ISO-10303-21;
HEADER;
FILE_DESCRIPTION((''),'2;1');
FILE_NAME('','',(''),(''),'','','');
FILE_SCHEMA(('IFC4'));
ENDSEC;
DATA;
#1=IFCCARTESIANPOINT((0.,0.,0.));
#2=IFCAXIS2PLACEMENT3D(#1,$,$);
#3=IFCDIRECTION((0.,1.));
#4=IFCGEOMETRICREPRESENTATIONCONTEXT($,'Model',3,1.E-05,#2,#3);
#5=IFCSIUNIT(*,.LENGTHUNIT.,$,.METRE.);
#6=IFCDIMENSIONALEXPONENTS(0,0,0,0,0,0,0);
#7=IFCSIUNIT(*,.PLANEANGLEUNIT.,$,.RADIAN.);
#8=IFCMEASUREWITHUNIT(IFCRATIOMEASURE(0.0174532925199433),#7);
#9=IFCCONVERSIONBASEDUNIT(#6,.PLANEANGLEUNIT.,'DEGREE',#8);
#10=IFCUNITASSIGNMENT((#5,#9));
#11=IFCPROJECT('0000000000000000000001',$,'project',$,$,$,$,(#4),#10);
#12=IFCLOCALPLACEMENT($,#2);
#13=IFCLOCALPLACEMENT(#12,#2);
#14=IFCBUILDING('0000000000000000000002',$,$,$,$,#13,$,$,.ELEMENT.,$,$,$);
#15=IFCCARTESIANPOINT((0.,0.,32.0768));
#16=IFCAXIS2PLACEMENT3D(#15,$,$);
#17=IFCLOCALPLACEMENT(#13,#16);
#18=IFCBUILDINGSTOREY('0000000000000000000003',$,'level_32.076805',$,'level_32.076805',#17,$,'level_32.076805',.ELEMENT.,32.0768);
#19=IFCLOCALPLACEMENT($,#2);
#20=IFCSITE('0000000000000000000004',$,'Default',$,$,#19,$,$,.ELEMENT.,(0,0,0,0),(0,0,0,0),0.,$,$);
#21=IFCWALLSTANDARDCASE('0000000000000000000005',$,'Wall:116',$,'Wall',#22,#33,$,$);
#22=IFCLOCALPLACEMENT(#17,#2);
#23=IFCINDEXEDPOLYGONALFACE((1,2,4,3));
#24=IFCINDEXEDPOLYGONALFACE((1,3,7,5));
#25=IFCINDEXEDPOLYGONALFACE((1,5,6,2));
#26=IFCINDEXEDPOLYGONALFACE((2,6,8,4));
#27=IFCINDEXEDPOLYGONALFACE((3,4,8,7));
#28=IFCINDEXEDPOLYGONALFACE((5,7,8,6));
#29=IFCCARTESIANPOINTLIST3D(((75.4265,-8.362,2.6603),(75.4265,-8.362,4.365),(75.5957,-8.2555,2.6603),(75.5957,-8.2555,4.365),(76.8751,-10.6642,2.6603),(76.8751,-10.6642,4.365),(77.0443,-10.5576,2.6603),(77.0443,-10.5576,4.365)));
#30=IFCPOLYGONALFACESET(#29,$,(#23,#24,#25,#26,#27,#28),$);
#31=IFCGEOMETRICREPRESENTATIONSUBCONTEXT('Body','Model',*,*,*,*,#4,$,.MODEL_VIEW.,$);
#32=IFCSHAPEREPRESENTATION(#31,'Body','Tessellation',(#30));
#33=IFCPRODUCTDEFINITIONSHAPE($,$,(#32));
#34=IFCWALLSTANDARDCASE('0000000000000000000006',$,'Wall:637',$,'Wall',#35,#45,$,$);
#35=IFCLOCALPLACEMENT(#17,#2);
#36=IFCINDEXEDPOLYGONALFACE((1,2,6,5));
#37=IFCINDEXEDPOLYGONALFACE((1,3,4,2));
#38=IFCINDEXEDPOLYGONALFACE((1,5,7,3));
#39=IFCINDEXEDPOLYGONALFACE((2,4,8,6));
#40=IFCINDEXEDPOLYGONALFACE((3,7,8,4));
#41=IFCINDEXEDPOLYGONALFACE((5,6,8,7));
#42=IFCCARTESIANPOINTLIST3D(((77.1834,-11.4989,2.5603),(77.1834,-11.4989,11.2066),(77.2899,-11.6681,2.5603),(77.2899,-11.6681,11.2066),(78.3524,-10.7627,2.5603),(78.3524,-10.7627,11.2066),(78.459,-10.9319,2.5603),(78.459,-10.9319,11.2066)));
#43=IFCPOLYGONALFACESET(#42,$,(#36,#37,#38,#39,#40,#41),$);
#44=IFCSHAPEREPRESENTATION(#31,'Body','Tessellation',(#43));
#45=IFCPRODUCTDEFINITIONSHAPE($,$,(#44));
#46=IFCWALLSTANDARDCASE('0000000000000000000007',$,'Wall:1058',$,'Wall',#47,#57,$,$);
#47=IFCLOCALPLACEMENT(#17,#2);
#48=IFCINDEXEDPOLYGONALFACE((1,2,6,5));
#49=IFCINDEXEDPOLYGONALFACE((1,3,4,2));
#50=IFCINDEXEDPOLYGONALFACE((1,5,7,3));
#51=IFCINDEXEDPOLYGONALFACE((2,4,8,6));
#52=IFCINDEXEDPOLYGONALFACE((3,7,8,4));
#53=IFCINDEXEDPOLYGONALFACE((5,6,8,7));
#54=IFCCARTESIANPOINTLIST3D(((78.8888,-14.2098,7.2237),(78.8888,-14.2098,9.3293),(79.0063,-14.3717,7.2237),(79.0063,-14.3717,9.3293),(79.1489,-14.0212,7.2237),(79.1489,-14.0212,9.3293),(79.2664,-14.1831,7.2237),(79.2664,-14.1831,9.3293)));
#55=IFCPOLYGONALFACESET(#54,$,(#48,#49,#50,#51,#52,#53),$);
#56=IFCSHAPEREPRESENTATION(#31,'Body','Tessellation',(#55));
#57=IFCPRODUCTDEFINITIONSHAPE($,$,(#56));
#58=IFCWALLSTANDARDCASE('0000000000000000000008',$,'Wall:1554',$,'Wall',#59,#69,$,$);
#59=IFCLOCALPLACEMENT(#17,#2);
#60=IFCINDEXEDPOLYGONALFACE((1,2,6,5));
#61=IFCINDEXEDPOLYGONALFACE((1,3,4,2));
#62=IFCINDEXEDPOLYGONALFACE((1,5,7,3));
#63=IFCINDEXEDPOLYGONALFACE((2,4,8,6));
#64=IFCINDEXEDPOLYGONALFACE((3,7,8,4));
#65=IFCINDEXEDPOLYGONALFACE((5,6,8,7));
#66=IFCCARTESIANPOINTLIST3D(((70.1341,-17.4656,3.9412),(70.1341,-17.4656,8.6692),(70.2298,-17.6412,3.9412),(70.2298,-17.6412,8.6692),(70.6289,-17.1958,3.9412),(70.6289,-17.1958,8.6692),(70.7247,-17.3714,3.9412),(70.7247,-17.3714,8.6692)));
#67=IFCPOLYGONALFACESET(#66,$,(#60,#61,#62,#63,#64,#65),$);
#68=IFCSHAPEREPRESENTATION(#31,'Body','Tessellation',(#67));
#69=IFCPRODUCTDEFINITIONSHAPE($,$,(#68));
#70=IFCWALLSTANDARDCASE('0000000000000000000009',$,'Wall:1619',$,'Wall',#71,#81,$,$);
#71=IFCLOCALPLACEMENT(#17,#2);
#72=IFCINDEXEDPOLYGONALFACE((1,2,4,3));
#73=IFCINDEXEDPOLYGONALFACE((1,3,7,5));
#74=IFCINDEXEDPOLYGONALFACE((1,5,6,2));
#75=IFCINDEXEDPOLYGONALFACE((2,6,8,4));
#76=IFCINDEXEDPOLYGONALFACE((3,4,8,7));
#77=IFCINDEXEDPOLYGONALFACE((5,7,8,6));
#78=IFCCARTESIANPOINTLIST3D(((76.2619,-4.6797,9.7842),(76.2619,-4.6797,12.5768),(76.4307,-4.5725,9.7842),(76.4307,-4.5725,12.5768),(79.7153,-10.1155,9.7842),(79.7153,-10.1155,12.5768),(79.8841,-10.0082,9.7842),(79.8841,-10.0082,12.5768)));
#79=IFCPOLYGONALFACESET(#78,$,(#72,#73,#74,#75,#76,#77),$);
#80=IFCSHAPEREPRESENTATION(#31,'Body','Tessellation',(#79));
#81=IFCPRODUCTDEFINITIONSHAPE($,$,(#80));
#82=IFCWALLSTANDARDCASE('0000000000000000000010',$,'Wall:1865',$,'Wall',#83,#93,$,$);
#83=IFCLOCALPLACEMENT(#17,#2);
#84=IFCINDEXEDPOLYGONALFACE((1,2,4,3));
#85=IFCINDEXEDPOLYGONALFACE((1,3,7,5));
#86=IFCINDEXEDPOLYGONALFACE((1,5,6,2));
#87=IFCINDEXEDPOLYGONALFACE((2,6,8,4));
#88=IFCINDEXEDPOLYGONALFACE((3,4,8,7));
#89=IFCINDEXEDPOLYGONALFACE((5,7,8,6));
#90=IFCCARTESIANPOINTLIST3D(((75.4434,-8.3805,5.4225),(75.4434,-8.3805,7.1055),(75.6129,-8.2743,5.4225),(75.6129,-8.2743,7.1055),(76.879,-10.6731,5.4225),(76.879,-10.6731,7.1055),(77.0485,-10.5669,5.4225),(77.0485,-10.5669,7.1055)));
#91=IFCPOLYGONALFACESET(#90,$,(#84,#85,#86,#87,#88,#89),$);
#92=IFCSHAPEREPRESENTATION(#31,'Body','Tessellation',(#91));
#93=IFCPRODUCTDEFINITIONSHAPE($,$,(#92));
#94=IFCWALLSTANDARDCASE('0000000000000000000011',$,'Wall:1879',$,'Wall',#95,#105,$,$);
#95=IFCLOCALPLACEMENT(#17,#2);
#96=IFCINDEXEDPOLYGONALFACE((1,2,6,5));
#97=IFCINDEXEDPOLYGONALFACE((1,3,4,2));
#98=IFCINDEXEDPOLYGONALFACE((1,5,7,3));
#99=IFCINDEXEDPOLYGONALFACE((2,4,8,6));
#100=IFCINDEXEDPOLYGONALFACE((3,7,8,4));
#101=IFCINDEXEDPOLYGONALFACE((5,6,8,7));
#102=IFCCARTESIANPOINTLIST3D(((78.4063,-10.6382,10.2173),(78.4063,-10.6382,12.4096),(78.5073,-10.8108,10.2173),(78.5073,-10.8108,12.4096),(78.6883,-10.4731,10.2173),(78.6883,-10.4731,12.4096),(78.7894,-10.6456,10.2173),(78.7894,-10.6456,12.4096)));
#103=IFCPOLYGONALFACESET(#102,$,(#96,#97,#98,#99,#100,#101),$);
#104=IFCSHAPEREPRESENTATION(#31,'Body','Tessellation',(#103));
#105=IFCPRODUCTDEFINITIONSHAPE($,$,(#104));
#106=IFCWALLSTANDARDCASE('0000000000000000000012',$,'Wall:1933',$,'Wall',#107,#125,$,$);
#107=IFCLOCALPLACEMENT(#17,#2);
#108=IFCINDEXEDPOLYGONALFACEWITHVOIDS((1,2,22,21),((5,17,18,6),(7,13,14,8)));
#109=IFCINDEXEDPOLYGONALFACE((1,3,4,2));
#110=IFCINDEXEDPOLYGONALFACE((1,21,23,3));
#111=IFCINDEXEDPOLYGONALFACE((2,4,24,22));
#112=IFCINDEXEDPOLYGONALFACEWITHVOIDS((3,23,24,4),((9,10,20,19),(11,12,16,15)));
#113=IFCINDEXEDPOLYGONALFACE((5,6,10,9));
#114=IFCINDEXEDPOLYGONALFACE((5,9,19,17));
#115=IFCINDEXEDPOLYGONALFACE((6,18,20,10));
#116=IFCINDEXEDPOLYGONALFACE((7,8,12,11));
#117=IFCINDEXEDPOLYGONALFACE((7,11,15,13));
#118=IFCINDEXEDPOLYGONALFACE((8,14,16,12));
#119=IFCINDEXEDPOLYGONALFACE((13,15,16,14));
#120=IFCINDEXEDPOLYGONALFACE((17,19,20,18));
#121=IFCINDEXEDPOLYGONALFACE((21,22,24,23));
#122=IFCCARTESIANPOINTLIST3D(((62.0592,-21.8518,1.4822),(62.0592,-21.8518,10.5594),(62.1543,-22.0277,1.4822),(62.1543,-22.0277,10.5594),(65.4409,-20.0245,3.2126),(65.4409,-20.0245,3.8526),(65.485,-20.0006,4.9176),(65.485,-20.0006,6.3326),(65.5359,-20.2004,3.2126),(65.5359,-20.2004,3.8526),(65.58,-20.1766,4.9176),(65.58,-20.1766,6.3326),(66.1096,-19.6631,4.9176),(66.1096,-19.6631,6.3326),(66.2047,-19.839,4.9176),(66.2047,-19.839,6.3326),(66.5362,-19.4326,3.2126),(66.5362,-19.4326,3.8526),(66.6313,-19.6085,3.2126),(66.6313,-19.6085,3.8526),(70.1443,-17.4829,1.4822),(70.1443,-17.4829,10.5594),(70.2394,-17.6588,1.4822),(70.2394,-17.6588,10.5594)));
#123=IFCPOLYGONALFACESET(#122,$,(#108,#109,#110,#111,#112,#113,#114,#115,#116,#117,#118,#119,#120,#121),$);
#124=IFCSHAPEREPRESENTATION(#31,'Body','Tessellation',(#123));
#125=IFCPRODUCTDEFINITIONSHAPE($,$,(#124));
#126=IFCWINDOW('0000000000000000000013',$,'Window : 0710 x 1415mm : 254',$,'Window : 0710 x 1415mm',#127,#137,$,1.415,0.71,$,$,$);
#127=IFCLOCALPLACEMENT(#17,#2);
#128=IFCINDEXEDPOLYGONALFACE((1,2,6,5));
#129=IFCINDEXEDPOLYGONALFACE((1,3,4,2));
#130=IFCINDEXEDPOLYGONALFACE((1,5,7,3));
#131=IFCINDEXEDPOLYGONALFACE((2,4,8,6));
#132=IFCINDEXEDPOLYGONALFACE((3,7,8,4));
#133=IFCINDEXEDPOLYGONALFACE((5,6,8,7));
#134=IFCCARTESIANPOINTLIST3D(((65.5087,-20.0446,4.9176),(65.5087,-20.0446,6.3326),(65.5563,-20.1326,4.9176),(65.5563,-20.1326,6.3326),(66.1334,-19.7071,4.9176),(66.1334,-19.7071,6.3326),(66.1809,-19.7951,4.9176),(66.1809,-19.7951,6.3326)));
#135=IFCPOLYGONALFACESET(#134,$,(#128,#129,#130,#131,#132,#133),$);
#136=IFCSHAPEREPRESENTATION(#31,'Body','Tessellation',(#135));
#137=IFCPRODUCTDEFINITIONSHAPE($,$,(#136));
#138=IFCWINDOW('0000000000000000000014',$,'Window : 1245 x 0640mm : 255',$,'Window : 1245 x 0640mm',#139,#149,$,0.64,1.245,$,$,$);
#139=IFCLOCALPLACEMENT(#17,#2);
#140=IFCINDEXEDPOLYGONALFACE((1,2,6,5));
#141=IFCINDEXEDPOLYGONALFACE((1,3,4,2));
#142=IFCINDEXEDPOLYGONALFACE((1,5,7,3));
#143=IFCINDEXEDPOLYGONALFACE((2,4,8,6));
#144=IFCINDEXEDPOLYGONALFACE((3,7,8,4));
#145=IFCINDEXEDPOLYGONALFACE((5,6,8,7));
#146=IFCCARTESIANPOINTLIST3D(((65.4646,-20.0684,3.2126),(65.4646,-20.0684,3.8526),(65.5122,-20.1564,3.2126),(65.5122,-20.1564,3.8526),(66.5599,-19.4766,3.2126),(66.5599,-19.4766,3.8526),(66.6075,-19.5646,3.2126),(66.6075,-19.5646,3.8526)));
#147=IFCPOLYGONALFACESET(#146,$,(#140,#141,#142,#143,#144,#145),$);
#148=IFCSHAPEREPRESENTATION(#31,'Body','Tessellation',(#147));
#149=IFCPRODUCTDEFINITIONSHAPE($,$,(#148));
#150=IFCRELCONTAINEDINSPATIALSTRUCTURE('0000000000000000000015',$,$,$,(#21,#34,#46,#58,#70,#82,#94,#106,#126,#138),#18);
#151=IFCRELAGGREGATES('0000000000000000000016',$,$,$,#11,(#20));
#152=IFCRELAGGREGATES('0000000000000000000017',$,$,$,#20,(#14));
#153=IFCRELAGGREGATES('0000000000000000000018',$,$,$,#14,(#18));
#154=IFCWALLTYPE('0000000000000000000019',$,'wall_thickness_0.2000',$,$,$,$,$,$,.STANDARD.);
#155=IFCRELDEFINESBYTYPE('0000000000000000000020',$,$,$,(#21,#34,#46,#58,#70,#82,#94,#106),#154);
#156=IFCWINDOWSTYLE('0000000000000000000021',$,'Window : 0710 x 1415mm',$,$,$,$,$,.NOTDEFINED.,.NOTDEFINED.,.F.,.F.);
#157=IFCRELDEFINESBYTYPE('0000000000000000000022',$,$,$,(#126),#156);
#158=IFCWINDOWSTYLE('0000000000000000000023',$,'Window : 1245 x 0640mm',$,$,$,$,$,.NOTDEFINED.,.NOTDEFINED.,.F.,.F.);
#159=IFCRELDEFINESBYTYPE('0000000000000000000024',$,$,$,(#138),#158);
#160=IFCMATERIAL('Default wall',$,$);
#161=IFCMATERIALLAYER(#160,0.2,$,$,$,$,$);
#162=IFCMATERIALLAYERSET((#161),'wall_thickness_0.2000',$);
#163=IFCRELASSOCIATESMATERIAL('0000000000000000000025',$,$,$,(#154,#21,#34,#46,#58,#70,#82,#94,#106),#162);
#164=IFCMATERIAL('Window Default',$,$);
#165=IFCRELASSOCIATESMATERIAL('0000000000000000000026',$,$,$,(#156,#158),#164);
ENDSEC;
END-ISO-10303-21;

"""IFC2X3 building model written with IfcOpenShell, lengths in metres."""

from ifc_helpers import new_model, entity, si_unit, converted_unit, direction, frame, frame_2d, origin, origin_2d_with_axis, place, context, subcontext, project, spatial, polyline, rectangle, outline, extrude, source, transform, mapped, material, layer, layer_set, layer_usage, type_object, type_shapes, element, fill, save


model = new_model("IFC2X3")

# Units and contexts
model_context = context("Model", 3, precision=1e-05, world=origin(), true_north=direction((0.0, 1.0)))
body_context = subcontext(model_context, "Body", "Model", "MODEL_VIEW")
ifc_project = project(units=[si_unit("LENGTHUNIT", "METRE"), converted_unit("PLANEANGLEUNIT", "DEGREE", entity("IfcRatioMeasure", 0.0174532925199433), si_unit("PLANEANGLEUNIT", "RADIAN"), dimensions=[0, 0, 0, 0, 0, 0, 0])], contexts=[model_context])

# Site, building, storey
site_placement = place(None, origin())
site = spatial("IfcSite", under=ifc_project, at=site_placement, Name="Default", CompositionType="ELEMENT", RefLatitude=(0, 0, 0, 0), RefLongitude=(0, 0, 0, 0), RefElevation=0.0)
placement_1 = place(None, origin())
building_placement = place(placement_1, origin())
building = spatial("IfcBuilding", under=site, at=building_placement, CompositionType="ELEMENT")
storey_placement = place(building_placement, frame((0.0, 0.0, 32.0768)))
storey = spatial("IfcBuildingStorey", under=building, at=storey_placement, Name="level_32.076805", ObjectType="level_32.076805", LongName="level_32.076805", CompositionType="ELEMENT", Elevation=32.0768)

# Walls
ifc_material_1 = material(Name="Default wall")
ifc_layer = layer(ifc_material_1, 0.2)
ifc_layer_set = layer_set([ifc_layer], Name="wall_thickness_0.2000")
ifc_layer_usage = layer_usage(ifc_layer_set, "AXIS2", "POSITIVE", -0.1)
wall_type = type_object("IfcWallType", Name="wall_thickness_0.2000", PredefinedType="STANDARD", material=ifc_layer_set)
placement_2 = place(building_placement, frame((0.0, 0.0, 34.7371)))
wall_1_placement = place(placement_2, frame((75.5111, -8.3087, 0.0), z_axis=(0.0, 0.0, 1.0), x_axis=(0.532569, -0.846387, 0.0)))
element("IfcWallStandardCase", 1, at=wall_1_placement, inside=storey, type_object=wall_type, material=ifc_layer_usage, Name="Wall:116", ObjectType="Wall", context=body_context, shape_type="SweptSolid", body=[
    extrude(outline(polyline([(2.72, -0.1), (2.72, 0.1), (0.0, 0.1), (0.0, -0.1), (2.72, -0.1)])), origin(), (0.0, 0.0, 1.0), 1.7048),
])
placement_3 = place(building_placement, frame((0.0, 0.0, 34.6371)))
wall_2_placement = place(placement_3, frame((77.2367, -11.5835, 0.0), z_axis=(0.0, 0.0, 1.0), x_axis=(0.846197, 0.532871, 0.0)))
element("IfcWallStandardCase", 2, at=wall_2_placement, inside=storey, type_object=wall_type, material=ifc_layer_usage, Name="Wall:637", ObjectType="Wall", context=body_context, shape_type="SweptSolid", body=[
    extrude(outline(polyline([(1.3815, -0.1), (1.3815, 0.1), (0.0, 0.1), (0.0, -0.1), (1.3815, -0.1)])), origin(), (0.0, 0.0, 1.0), 8.6464),
])
placement_4 = place(building_placement, frame((0.0, 0.0, 39.3005)))
wall_3_placement = place(placement_4, frame((79.2077, -14.1021, 0.0), z_axis=(0.0, 0.0, 1.0), x_axis=(-0.809466, -0.587167, 0.0)))
element("IfcWallStandardCase", 3, at=wall_3_placement, inside=storey, type_object=wall_type, material=ifc_layer_usage, Name="Wall:1058", ObjectType="Wall", context=body_context, shape_type="SweptSolid", body=[
    extrude(outline(polyline([(0.3213, -0.1), (0.3213, 0.1), (0.0, 0.1), (0.0, -0.1), (0.3213, -0.1)])), origin(), (0.0, 0.0, 1.0), 2.1056),
])
placement_5 = place(building_placement, frame((0.0, 0.0, 36.018)))
wall_4_placement = place(placement_5, frame((70.6768, -17.2836, 0.0), z_axis=(0.0, 0.0, 1.0), x_axis=(-0.878023, -0.478618, 0.0)))
element("IfcWallStandardCase", 4, at=wall_4_placement, inside=storey, type_object=wall_type, material=ifc_layer_usage, Name="Wall:1554", ObjectType="Wall", context=body_context, shape_type="SweptSolid", body=[
    extrude(outline(polyline([(0.5636, -0.1), (0.5636, 0.1), (0.0, 0.1), (0.0, -0.1), (0.5636, -0.1)])), origin(), (0.0, 0.0, 1.0), 4.728),
])
placement_6 = place(building_placement, frame((0.0, 0.0, 41.861)))
wall_5_placement = place(placement_6, frame((79.7997, -10.0618, 0.0), z_axis=(0.0, 0.0, 1.0), x_axis=(-0.536247, 0.844061, 0.0)))
element("IfcWallStandardCase", 5, at=wall_5_placement, inside=storey, type_object=wall_type, material=ifc_layer_usage, Name="Wall:1619", ObjectType="Wall", context=body_context, shape_type="SweptSolid", body=[
    extrude(outline(polyline([(6.44, -0.1), (6.44, 0.1), (0.0, 0.1), (0.0, -0.1), (6.44, -0.1)])), origin(), (0.0, 0.0, 1.0), 2.7926),
])
placement_7 = place(building_placement, frame((0.0, 0.0, 37.4993)))
wall_6_placement = place(placement_7, frame((75.5281, -8.3274, 0.0), z_axis=(0.0, 0.0, 1.0), x_axis=(0.530721, -0.847547, 0.0)))
element("IfcWallStandardCase", 6, at=wall_6_placement, inside=storey, type_object=wall_type, material=ifc_layer_usage, Name="Wall:1865", ObjectType="Wall", context=body_context, shape_type="SweptSolid", body=[
    extrude(outline(polyline([(2.705, -0.1), (2.705, 0.1), (0.0, 0.1), (0.0, -0.1), (2.705, -0.1)])), origin(), (0.0, 0.0, 1.0), 1.6831),
])
placement_8 = place(building_placement, frame((0.0, 0.0, 42.2941)))
wall_7_placement = place(placement_8, frame((78.7388, -10.5594, 0.0), z_axis=(0.0, 0.0, 1.0), x_axis=(-0.862899, -0.505376, 0.0)))
element("IfcWallStandardCase", 7, at=wall_7_placement, inside=storey, type_object=wall_type, material=ifc_layer_usage, Name="Wall:1879", ObjectType="Wall", context=body_context, shape_type="SweptSolid", body=[
    extrude(outline(polyline([(0.3269, -0.1), (0.3269, 0.1), (0.0, 0.1), (0.0, -0.1), (0.3269, -0.1)])), origin(), (0.0, 0.0, 1.0), 2.1922),
])

# Wall, openings, windows
placement_9 = place(building_placement, frame((0.0, 0.0, 33.559)))
wall_8_placement = place(placement_9, frame((70.1918, -17.5709, 0.0), z_axis=(0.0, 0.0, 1.0), x_axis=(-0.879771, -0.475398, 0.0)))
wall_8 = element("IfcWallStandardCase", 8, at=wall_8_placement, inside=storey, type_object=wall_type, material=ifc_layer_usage, Name="Wall:1933", ObjectType="Wall", context=body_context, shape_type="SweptSolid", body=[
    extrude(outline(polyline([(9.19, -0.1), (9.19, 0.1), (0.0, 0.1), (0.0, -0.1), (9.19, -0.1)])), origin(), (0.0, 0.0, 1.0), 9.0772),
])
opening_1_placement = place(wall_8_placement, frame((4.5861, -0.1, 3.4354)))
opening_1 = element("IfcOpeningElement", 9, at=opening_1_placement, cuts=wall_8, ObjectType="Opening", context=body_context, shape_type="SweptSolid", body=[
    extrude(rectangle(XDim=0.71, YDim=1.415, at=frame_2d((0.7075, 0.355), x_axis=(0.0, 1.0))), frame((0.0, 0.0, 0.0), z_axis=(0.0, 1.0, 0.0), x_axis=(0.0, 0.0, 1.0)), (0.0, 0.0, 1.0), 0.2),
])
opening_2_placement = place(wall_8_placement, frame((4.1012, -0.1, 1.7304)))
opening_2 = element("IfcOpeningElement", 10, at=opening_2_placement, cuts=wall_8, ObjectType="Opening", context=body_context, shape_type="SweptSolid", body=[
    extrude(rectangle(XDim=1.245, YDim=0.64, at=frame_2d((0.32, 0.6225), x_axis=(0.0, 1.0))), frame((0.0, 0.0, 0.0), z_axis=(0.0, 1.0, 0.0), x_axis=(0.0, 0.0, 1.0)), (0.0, 0.0, 1.0), 0.2),
])
ifc_material_2 = material(Name="Window Default")
window_style_1 = type_object("IfcWindowStyle", Name="Window : 0710 x 1415mm", ConstructionType="NOTDEFINED", OperationType="NOTDEFINED", ParameterTakesPrecedence=False, Sizeable=False, material=ifc_material_2)
shared_shape_1 = source(origin(), body_context, "Body", "SweptSolid", [
    extrude(rectangle(XDim=0.1, YDim=0.71, at=origin_2d_with_axis()), frame((0.355, 0.1, 0.0), z_axis=(0.0, 0.0, 1.0), x_axis=(0.0, 1.0, 0.0)), (0.0, 0.0, 1.0), 1.415),
])
type_shapes(window_style_1, [shared_shape_1])
window_1_placement = place(opening_1_placement, origin())
window_1 = element("IfcWindow", 11, at=window_1_placement, inside=storey, type_object=window_style_1, Name="Window : 0710 x 1415mm : 254", ObjectType="Window : 0710 x 1415mm", OverallHeight=1.415, OverallWidth=0.71, context=body_context, shape_type="MappedRepresentation", body=[
    mapped(shared_shape_1, transform((0.0, 0.0, 0.0), scale=1.0)),
])
fill(opening_1, window_1)
window_style_2 = type_object("IfcWindowStyle", Name="Window : 1245 x 0640mm", ConstructionType="NOTDEFINED", OperationType="NOTDEFINED", ParameterTakesPrecedence=False, Sizeable=False, material=ifc_material_2)
shared_shape_2 = source(origin(), body_context, "Body", "SweptSolid", [
    extrude(rectangle(XDim=0.1, YDim=1.245, at=origin_2d_with_axis()), frame((0.6225, 0.1, 0.0), z_axis=(0.0, 0.0, 1.0), x_axis=(0.0, 1.0, 0.0)), (0.0, 0.0, 1.0), 0.64),
])
type_shapes(window_style_2, [shared_shape_2])
window_2_placement = place(opening_2_placement, origin())
window_2 = element("IfcWindow", 12, at=window_2_placement, inside=storey, type_object=window_style_2, Name="Window : 1245 x 0640mm : 255", ObjectType="Window : 1245 x 0640mm", OverallHeight=0.64, OverallWidth=1.245, context=body_context, shape_type="MappedRepresentation", body=[
    mapped(shared_shape_2, transform((0.0, 0.0, 0.0), scale=1.0)),
])
fill(opening_2, window_2)

save(model, "model.ifc")
